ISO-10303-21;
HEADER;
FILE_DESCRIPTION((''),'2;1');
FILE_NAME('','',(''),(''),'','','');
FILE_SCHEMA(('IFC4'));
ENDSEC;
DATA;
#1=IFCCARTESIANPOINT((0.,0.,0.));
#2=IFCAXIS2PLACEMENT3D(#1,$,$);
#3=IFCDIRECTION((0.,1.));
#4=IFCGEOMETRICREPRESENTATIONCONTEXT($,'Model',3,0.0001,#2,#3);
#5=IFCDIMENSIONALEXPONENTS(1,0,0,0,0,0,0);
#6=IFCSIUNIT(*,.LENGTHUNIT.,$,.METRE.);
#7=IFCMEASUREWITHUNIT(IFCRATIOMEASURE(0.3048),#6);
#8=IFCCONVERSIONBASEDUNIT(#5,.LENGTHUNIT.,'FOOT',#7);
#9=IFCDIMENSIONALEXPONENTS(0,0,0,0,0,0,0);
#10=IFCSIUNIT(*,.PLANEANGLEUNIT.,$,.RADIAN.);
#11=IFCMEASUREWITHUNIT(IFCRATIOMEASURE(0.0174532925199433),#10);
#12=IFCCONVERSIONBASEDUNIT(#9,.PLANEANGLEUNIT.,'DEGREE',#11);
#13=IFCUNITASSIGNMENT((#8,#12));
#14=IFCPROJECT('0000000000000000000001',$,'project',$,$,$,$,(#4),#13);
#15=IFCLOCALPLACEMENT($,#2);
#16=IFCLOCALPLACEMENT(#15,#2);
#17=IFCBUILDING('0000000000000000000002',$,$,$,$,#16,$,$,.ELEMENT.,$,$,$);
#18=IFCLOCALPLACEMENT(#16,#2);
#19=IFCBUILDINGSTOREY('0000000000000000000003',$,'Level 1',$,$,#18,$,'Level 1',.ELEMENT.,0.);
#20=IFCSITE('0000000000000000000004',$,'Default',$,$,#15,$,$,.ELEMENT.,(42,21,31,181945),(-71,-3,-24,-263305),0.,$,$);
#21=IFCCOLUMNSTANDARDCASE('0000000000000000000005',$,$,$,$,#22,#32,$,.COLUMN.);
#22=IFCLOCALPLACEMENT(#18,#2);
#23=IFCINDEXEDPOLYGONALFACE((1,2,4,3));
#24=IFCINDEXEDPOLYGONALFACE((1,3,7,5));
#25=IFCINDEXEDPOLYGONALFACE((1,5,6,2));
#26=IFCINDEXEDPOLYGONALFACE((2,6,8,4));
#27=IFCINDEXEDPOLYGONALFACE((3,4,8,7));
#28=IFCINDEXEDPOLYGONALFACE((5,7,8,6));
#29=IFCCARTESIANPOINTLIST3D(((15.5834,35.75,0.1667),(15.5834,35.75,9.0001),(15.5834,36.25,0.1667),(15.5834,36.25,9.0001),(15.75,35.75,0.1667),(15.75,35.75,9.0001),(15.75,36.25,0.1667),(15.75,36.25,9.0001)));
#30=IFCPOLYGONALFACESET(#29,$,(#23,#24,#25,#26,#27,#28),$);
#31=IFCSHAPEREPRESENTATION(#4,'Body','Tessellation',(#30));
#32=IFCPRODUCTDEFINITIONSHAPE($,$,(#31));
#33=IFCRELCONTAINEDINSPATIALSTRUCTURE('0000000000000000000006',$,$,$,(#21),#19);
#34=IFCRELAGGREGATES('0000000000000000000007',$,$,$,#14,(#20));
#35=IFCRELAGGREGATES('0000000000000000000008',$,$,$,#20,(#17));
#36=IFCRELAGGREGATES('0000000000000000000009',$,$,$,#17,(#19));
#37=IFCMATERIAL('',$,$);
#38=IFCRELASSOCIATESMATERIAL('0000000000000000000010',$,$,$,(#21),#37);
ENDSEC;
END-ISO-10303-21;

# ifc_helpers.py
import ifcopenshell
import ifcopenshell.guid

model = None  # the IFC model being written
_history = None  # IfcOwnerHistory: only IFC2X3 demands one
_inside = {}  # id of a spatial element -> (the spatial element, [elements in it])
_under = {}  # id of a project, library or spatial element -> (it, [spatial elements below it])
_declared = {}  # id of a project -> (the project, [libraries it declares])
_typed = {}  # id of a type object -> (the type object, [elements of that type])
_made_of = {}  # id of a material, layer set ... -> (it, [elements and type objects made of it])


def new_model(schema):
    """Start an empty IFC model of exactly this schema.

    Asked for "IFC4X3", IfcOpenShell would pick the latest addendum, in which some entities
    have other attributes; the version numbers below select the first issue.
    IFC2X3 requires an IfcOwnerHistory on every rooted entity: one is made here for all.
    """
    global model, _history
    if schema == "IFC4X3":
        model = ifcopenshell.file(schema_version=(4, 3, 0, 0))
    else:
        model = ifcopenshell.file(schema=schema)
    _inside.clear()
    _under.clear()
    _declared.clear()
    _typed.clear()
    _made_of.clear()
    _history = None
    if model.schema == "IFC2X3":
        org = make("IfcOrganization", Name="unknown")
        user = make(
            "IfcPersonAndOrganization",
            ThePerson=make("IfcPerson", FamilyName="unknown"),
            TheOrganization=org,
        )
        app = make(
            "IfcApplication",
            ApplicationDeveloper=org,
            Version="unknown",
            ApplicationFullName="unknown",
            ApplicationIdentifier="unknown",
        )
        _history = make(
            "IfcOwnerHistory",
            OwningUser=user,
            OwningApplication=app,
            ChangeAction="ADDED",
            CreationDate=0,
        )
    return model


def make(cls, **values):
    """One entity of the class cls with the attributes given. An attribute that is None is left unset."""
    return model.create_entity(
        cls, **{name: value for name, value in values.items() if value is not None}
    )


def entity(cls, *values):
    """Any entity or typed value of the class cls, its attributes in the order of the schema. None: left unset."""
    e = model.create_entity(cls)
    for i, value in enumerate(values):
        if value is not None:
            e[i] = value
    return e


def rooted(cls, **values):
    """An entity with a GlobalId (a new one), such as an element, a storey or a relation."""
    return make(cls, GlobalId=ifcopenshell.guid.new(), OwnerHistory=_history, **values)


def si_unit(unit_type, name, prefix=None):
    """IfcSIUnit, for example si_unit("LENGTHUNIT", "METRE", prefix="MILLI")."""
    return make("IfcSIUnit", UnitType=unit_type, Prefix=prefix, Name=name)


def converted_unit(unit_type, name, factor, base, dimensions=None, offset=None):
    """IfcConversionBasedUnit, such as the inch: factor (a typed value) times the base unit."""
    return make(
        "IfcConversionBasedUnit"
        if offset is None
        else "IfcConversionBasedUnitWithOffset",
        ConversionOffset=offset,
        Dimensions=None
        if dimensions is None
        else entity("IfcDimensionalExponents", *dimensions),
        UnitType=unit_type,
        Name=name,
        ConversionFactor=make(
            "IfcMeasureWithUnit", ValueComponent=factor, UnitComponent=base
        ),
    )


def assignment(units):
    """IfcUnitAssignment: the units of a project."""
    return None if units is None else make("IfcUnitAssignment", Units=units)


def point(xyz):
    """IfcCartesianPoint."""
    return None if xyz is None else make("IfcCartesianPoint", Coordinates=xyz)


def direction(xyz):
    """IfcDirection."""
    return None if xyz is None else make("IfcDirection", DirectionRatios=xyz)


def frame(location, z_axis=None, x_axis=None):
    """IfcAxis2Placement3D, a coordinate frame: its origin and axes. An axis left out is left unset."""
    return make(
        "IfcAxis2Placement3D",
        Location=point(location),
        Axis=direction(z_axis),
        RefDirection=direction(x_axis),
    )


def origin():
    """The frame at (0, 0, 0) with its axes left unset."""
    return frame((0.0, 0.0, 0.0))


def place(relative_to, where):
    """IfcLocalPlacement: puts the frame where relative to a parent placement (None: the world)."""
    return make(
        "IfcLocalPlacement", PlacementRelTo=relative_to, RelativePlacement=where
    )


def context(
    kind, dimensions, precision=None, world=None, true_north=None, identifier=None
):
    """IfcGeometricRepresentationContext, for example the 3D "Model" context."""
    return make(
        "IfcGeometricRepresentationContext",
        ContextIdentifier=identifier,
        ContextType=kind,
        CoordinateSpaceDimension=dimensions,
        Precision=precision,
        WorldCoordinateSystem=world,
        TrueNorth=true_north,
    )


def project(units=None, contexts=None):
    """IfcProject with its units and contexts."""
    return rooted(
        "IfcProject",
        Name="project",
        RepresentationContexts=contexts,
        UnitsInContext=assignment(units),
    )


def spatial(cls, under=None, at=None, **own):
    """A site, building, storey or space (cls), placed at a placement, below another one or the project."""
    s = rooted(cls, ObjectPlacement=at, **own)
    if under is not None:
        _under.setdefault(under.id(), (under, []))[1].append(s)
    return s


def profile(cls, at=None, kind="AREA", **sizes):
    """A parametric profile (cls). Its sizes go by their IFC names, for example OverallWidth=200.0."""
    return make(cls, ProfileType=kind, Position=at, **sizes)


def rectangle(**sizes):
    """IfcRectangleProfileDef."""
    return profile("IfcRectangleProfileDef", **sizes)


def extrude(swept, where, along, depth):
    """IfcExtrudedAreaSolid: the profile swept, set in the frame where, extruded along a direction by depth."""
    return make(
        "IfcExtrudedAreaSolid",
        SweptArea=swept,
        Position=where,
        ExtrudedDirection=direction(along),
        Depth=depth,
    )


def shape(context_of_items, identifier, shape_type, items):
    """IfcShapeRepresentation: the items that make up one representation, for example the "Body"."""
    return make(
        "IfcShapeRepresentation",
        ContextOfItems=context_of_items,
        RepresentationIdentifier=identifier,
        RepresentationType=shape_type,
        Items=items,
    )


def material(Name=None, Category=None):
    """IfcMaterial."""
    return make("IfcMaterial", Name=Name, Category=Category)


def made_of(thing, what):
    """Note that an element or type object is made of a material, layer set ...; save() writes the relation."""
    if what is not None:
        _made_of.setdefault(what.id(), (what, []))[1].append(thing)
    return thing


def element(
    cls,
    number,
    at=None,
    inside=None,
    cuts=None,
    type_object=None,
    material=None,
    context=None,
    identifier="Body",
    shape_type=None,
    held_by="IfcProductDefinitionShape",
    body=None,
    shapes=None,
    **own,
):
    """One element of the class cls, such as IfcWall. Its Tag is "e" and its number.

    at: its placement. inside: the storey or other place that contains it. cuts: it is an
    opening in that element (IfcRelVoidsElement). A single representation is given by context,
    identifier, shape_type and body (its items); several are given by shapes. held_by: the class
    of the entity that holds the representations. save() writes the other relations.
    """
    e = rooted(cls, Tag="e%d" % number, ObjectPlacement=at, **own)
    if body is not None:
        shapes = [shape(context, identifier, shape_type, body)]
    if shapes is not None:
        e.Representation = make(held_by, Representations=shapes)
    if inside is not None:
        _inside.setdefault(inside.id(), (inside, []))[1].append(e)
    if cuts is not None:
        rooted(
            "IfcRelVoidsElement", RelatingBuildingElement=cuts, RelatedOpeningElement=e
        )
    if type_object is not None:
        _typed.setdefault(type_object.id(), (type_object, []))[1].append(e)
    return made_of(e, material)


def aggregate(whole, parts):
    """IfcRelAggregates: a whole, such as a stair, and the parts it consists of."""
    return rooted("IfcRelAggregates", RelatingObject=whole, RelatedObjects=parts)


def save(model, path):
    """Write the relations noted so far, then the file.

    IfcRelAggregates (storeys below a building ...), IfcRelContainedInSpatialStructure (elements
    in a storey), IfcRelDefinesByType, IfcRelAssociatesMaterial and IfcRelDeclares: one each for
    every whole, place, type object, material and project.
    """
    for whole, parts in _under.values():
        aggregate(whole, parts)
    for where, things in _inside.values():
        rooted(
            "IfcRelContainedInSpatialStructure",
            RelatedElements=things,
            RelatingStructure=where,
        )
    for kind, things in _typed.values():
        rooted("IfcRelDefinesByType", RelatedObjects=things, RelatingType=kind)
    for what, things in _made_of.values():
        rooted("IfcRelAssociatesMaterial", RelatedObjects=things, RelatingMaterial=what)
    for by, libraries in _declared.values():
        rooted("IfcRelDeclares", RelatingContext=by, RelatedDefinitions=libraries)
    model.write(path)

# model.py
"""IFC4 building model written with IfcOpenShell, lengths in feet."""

from ifc_helpers import new_model, entity, si_unit, converted_unit, direction, frame, origin, place, context, project, spatial, rectangle, extrude, material, element, save


model = new_model("IFC4")

# Units and contexts
model_context = context("Model", 3, precision=0.0001, world=origin(), true_north=direction((0.0, 1.0)))
ifc_project = project(units=[converted_unit("LENGTHUNIT", "FOOT", entity("IfcRatioMeasure", 0.3048), si_unit("LENGTHUNIT", "METRE"), dimensions=[1, 0, 0, 0, 0, 0, 0]), converted_unit("PLANEANGLEUNIT", "DEGREE", entity("IfcRatioMeasure", 0.0174532925199433), si_unit("PLANEANGLEUNIT", "RADIAN"), dimensions=[0, 0, 0, 0, 0, 0, 0])], contexts=[model_context])

# Site, building, storey
site_placement = place(None, origin())
site = spatial("IfcSite", under=ifc_project, at=site_placement, Name="Default", CompositionType="ELEMENT", RefLatitude=(42, 21, 31, 181945), RefLongitude=(-71, -3, -24, -263305), RefElevation=0.0)
building_placement = place(site_placement, origin())
building = spatial("IfcBuilding", under=site, at=building_placement, CompositionType="ELEMENT")
storey_placement = place(building_placement, origin())
storey = spatial("IfcBuildingStorey", under=building, at=storey_placement, Name="Level 1", LongName="Level 1", CompositionType="ELEMENT", Elevation=0.0)

# Column
ifc_material_1 = material(Name="")
placement_1 = place(storey_placement, frame((0.25, 36.0, 0.0)))
column_1_placement = place(placement_1, frame((15.4167, 0.0, 0.1667), z_axis=(0.0, 0.0, 1.0), x_axis=(1.0, 0.0, 0.0)))
element("IfcColumnStandardCase", 1, at=column_1_placement, inside=storey, material=ifc_material_1, PredefinedType="COLUMN", context=model_context, shape_type="SweptSolid", body=[
    extrude(rectangle(XDim=0.1667, YDim=0.5), origin(), (0.0, 0.0, 1.0), 8.8334),
])

save(model, "model.ifc")
